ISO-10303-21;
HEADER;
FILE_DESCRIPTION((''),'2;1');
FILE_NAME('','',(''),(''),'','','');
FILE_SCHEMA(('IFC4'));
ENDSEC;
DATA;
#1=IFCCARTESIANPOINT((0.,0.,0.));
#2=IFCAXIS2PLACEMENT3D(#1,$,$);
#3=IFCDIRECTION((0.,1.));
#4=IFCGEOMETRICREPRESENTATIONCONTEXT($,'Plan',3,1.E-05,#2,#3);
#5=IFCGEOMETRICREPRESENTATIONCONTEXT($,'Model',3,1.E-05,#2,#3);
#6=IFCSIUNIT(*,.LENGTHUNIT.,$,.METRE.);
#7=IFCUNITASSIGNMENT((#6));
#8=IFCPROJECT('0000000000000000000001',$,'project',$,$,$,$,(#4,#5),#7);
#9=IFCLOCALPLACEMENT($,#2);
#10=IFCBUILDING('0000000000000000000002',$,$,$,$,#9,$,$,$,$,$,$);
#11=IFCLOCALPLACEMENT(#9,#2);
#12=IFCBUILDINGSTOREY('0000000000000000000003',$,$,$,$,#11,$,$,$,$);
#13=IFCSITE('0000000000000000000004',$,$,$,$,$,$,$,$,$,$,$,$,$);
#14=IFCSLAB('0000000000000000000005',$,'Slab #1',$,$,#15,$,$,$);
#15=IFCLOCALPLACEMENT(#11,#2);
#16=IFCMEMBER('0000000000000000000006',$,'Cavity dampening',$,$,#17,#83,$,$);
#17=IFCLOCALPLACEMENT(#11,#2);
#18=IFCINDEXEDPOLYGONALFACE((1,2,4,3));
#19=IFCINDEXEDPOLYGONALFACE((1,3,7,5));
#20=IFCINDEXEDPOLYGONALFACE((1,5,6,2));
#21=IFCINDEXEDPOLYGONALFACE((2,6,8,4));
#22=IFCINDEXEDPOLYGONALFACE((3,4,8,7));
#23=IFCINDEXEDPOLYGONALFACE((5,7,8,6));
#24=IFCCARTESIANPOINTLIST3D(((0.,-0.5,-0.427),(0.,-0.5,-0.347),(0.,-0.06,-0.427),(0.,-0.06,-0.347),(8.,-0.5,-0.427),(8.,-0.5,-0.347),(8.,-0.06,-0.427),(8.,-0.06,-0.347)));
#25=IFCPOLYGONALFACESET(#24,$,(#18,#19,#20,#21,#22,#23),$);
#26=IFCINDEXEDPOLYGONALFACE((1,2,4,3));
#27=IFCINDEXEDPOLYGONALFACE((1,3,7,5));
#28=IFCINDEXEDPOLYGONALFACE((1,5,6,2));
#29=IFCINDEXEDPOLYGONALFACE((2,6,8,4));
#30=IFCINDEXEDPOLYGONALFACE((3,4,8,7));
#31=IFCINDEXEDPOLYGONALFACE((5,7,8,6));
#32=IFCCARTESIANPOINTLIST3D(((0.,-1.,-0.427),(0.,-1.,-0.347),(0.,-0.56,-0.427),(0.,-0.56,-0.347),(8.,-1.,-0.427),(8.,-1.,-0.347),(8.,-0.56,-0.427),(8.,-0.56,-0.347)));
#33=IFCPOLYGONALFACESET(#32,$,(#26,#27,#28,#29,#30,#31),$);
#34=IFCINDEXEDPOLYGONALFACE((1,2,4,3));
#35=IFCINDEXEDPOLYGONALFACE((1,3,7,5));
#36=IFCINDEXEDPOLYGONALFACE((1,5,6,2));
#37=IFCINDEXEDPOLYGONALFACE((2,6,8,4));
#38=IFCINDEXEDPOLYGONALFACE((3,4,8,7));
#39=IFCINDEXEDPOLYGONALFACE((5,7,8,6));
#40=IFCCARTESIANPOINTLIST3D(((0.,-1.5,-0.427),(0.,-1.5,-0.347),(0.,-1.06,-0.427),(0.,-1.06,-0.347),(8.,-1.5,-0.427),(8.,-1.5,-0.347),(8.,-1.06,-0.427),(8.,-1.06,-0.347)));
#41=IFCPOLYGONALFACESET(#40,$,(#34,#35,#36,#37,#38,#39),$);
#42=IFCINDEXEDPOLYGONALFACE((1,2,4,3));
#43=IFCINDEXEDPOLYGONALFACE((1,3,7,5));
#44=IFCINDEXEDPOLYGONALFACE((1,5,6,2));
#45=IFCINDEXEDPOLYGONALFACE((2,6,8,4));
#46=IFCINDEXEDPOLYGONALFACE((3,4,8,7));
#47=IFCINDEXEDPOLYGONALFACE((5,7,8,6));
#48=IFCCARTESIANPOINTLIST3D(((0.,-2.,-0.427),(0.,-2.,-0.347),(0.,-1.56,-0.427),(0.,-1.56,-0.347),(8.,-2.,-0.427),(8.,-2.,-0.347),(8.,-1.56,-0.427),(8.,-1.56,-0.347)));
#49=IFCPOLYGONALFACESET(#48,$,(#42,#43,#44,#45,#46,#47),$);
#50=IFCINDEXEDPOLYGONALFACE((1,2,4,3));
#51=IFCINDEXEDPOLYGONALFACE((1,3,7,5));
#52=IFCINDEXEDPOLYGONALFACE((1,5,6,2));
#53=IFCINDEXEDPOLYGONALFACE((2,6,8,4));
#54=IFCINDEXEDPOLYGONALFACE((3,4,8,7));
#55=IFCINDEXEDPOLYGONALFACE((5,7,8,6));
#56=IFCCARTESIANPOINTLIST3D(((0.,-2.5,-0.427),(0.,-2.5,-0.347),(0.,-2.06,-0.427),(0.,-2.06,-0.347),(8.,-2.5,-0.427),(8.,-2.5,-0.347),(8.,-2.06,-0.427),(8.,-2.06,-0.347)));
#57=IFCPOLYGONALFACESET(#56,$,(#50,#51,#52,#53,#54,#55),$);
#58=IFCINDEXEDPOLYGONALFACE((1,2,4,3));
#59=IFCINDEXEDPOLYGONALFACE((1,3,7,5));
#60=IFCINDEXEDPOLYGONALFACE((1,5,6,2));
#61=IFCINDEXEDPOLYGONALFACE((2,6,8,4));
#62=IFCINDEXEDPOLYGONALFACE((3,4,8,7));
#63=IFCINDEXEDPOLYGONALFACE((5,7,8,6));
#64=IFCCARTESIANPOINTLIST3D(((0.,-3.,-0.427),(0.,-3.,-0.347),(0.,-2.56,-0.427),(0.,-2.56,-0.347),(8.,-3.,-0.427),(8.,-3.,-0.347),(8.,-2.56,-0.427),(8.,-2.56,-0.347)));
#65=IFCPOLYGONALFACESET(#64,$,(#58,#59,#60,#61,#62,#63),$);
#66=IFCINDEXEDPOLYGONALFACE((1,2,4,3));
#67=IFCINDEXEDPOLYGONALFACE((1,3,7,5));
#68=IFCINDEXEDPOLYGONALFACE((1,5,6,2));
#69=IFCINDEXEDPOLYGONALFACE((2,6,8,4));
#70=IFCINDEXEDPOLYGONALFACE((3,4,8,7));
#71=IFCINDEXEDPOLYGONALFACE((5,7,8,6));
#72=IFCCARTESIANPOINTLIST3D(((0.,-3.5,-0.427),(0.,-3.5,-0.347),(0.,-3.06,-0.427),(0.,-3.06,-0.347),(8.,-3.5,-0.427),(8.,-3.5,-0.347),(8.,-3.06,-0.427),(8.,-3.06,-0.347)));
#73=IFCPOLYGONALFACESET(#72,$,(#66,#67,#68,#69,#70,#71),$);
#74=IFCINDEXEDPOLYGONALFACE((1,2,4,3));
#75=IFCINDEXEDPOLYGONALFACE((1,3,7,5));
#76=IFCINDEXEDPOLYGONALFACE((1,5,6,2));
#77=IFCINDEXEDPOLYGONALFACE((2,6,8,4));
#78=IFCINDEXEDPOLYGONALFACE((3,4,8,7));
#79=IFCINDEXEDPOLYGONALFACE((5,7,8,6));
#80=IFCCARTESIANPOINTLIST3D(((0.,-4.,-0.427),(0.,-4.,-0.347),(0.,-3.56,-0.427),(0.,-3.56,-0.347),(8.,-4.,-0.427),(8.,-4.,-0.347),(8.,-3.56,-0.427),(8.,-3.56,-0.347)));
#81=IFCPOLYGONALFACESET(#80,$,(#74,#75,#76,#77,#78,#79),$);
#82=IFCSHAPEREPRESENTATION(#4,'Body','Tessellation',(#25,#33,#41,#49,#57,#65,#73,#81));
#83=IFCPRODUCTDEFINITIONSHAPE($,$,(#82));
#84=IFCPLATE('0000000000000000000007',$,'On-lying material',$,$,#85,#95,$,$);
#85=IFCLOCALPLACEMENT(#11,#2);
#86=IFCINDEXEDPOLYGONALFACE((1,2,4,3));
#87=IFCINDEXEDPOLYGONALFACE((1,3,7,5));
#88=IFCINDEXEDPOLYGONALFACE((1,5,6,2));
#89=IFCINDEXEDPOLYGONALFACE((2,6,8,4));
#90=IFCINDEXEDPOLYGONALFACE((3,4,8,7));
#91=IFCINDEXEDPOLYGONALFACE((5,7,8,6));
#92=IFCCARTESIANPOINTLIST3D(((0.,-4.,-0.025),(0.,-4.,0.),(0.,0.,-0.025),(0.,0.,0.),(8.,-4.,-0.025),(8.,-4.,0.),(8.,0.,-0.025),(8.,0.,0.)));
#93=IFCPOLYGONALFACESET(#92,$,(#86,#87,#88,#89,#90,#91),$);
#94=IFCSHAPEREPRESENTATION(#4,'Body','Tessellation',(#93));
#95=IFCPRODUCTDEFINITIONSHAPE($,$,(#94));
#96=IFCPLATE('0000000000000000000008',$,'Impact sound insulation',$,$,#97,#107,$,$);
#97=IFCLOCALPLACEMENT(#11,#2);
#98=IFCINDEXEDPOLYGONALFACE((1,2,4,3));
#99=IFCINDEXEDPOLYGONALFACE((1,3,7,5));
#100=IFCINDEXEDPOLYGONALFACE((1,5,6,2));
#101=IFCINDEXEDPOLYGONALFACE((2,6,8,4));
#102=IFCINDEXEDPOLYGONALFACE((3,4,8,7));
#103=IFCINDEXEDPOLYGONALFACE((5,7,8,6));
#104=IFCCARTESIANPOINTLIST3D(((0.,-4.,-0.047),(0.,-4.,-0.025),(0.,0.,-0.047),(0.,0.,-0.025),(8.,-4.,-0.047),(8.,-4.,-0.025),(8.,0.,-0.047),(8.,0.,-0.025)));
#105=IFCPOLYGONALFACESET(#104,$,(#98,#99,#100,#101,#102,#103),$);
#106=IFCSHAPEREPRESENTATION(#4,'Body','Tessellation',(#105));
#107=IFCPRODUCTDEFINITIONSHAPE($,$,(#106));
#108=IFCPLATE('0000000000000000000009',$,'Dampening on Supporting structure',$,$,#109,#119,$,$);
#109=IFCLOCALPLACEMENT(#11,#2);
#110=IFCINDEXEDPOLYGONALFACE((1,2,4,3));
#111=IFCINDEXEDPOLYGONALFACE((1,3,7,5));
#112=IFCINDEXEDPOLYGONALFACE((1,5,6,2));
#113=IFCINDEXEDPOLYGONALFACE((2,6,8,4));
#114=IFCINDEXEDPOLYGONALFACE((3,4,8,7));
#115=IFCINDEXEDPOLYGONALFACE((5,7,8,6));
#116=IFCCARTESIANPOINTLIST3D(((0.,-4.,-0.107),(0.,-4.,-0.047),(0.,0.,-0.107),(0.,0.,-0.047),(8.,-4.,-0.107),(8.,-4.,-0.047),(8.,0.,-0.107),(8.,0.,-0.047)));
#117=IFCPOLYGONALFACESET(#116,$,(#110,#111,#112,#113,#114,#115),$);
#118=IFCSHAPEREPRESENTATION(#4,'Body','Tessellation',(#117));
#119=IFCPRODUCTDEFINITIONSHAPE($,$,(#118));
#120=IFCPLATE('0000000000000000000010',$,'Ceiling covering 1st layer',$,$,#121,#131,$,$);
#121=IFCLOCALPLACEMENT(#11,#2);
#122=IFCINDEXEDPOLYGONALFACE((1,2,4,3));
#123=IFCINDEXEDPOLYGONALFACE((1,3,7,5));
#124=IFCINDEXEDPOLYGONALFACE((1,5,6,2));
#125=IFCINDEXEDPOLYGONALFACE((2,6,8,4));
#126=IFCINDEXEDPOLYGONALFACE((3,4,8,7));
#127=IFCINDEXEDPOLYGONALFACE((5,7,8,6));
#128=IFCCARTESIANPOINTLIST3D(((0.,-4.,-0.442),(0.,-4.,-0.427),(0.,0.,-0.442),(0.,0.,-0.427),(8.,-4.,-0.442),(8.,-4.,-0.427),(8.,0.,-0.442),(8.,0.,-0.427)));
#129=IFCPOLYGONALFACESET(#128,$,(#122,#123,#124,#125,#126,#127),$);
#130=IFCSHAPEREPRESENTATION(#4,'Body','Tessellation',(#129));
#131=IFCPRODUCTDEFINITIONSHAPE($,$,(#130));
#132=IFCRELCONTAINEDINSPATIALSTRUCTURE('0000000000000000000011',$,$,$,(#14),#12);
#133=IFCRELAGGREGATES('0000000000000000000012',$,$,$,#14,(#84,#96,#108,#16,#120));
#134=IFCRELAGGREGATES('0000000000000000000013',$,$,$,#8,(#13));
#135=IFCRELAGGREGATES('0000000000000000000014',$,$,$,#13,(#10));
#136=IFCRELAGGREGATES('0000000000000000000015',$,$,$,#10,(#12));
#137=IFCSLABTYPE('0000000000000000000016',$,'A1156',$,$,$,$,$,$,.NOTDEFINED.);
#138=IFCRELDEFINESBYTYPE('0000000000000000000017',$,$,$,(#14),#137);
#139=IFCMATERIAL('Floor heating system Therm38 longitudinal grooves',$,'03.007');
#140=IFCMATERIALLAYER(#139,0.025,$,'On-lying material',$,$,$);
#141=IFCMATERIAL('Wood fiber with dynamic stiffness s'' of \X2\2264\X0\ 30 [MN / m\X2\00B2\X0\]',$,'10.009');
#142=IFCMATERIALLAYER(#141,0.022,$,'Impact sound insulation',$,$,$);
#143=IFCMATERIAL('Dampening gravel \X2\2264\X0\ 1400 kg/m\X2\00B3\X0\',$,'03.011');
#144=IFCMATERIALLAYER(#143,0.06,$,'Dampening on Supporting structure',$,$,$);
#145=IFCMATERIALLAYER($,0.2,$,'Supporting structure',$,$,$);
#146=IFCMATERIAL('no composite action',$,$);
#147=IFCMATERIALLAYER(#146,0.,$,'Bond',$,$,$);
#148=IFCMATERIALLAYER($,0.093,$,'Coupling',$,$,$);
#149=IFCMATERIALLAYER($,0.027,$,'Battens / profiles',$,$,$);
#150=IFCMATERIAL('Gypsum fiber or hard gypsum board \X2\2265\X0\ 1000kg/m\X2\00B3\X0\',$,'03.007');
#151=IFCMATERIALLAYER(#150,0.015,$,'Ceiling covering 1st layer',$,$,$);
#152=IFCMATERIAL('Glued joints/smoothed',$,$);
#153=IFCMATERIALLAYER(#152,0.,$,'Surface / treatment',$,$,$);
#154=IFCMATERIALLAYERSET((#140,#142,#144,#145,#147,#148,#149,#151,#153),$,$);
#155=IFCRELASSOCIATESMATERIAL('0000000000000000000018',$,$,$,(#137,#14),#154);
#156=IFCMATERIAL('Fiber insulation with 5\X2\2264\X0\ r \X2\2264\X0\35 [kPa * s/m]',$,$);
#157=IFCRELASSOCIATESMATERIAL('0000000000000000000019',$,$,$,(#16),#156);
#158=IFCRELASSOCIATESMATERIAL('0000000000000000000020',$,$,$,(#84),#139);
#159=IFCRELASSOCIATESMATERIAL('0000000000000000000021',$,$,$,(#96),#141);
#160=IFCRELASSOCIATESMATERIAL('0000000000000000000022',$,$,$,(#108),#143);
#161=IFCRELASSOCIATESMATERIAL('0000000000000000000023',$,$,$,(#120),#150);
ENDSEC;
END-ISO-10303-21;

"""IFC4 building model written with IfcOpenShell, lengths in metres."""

from ifc_helpers import new_model, si_unit, direction, frame, frame_2d, origin, origin_with_axes, place, context, project, spatial, rectangle, extrude, material, layer, layer_set, type_object, element, aggregate, save


model = new_model("IFC4")

# Units and contexts
plan_context = context("Plan", 3, precision=1e-05, world=origin(), true_north=direction((0.0, 1.0)))
model_context = context("Model", 3, precision=1e-05, world=origin(), true_north=direction((0.0, 1.0)))
ifc_project = project(units=[si_unit("LENGTHUNIT", "METRE")], contexts=[plan_context, model_context])

# Site, building, storey
site = spatial("IfcSite", under=ifc_project)
building_placement = place(None, origin())
building = spatial("IfcBuilding", under=site, at=building_placement)
storey_placement = place(building_placement, origin())
storey = spatial("IfcBuildingStorey", under=building, at=storey_placement)

# Slab, member, plates
ifc_material_1 = material(Name="Floor heating system Therm38 longitudinal grooves", Category="03.007")
ifc_layer_1 = layer(ifc_material_1, 0.025, Name="On-lying material")
ifc_material_2 = material(Name="Wood fiber with dynamic stiffness s' of ≤ 30 [MN / m²]", Category="10.009")
ifc_layer_2 = layer(ifc_material_2, 0.022, Name="Impact sound insulation")
ifc_material_3 = material(Name="Dampening gravel ≤ 1400 kg/m³", Category="03.011")
ifc_layer_3 = layer(ifc_material_3, 0.06, Name="Dampening on Supporting structure")
ifc_layer_4 = layer(None, 0.2, Name="Supporting structure")
ifc_material_4 = material(Name="no composite action")
ifc_layer_5 = layer(ifc_material_4, 0.0, Name="Bond")
ifc_layer_6 = layer(None, 0.093, Name="Coupling")
ifc_layer_7 = layer(None, 0.027, Name="Battens / profiles")
ifc_material_5 = material(Name="Gypsum fiber or hard gypsum board ≥ 1000kg/m³", Category="03.007")
ifc_layer_8 = layer(ifc_material_5, 0.015, Name="Ceiling covering 1st layer")
ifc_material_6 = material(Name="Glued joints/smoothed")
ifc_layer_9 = layer(ifc_material_6, 0.0, Name="Surface / treatment")
ifc_layer_set = layer_set([ifc_layer_1, ifc_layer_2, ifc_layer_3, ifc_layer_4, ifc_layer_5, ifc_layer_6, ifc_layer_7, ifc_layer_8, ifc_layer_9])
slab_type = type_object("IfcSlabType", Name="A1156", PredefinedType="NOTDEFINED", material=ifc_layer_set)
slab_placement = place(None, frame((0.0, 0.0, 0.0), z_axis=(0.0, 0.0, -1.0), x_axis=(1.0, 0.0, 0.0)))
slab = element("IfcSlab", 1, at=slab_placement, inside=storey, type_object=slab_type, material=ifc_layer_set, Name="Slab #1")
ifc_material_7 = material(Name="Fiber insulation with 5≤ r ≤35 [kPa * s/m]")
member_1_placement = place(slab_placement, origin())
member_1 = element("IfcMember", 2, at=member_1_placement, material=ifc_material_7, Name="Cavity dampening", context=plan_context, shape_type="SweptSolid", body=[
    extrude(rectangle(XDim=0.44, YDim=0.08, at=frame_2d((0.22, 0.04), x_axis=(1.0, 0.0))), frame((0.0, 0.06, 0.347), z_axis=(1.0, 0.0, 0.0), x_axis=(0.0, 1.0, 0.0)), (0.0, 0.0, 1.0), 8.0),
    extrude(rectangle(XDim=0.44, YDim=0.08, at=frame_2d((0.22, 0.04), x_axis=(1.0, 0.0))), frame((0.0, 0.56, 0.347), z_axis=(1.0, 0.0, 0.0), x_axis=(0.0, 1.0, 0.0)), (0.0, 0.0, 1.0), 8.0),
    extrude(rectangle(XDim=0.44, YDim=0.08, at=frame_2d((0.22, 0.04), x_axis=(1.0, 0.0))), frame((0.0, 1.06, 0.347), z_axis=(1.0, 0.0, 0.0), x_axis=(0.0, 1.0, 0.0)), (0.0, 0.0, 1.0), 8.0),
    extrude(rectangle(XDim=0.44, YDim=0.08, at=frame_2d((0.22, 0.04), x_axis=(1.0, 0.0))), frame((0.0, 1.56, 0.347), z_axis=(1.0, 0.0, 0.0), x_axis=(0.0, 1.0, 0.0)), (0.0, 0.0, 1.0), 8.0),
    extrude(rectangle(XDim=0.44, YDim=0.08, at=frame_2d((0.22, 0.04), x_axis=(1.0, 0.0))), frame((0.0, 2.06, 0.347), z_axis=(1.0, 0.0, 0.0), x_axis=(0.0, 1.0, 0.0)), (0.0, 0.0, 1.0), 8.0),
    extrude(rectangle(XDim=0.44, YDim=0.08, at=frame_2d((0.22, 0.04), x_axis=(1.0, 0.0))), frame((0.0, 2.56, 0.347), z_axis=(1.0, 0.0, 0.0), x_axis=(0.0, 1.0, 0.0)), (0.0, 0.0, 1.0), 8.0),
    extrude(rectangle(XDim=0.44, YDim=0.08, at=frame_2d((0.22, 0.04), x_axis=(1.0, 0.0))), frame((0.0, 3.06, 0.347), z_axis=(1.0, 0.0, 0.0), x_axis=(0.0, 1.0, 0.0)), (0.0, 0.0, 1.0), 8.0),
    extrude(rectangle(XDim=0.44, YDim=0.08, at=frame_2d((0.22, 0.04), x_axis=(1.0, 0.0))), frame((0.0, 3.56, 0.347), z_axis=(1.0, 0.0, 0.0), x_axis=(0.0, 1.0, 0.0)), (0.0, 0.0, 1.0), 8.0),
])
plate_1_placement = place(slab_placement, origin())
plate_1 = element("IfcPlate", 3, at=plate_1_placement, material=ifc_material_1, Name="On-lying material", context=plan_context, shape_type="SweptSolid", body=[
    extrude(rectangle(XDim=8.0, YDim=4.0, at=frame_2d((4.0, 2.0), x_axis=(1.0, 0.0))), origin_with_axes(), (0.0, 0.0, 1.0), 0.025),
])
plate_2_placement = place(slab_placement, origin())
plate_2 = element("IfcPlate", 4, at=plate_2_placement, material=ifc_material_2, Name="Impact sound insulation", context=plan_context, shape_type="SweptSolid", body=[
    extrude(rectangle(XDim=8.0, YDim=4.0, at=frame_2d((4.0, 2.0), x_axis=(1.0, 0.0))), frame((0.0, 0.0, 0.025), z_axis=(0.0, 0.0, 1.0), x_axis=(1.0, 0.0, 0.0)), (0.0, 0.0, 1.0), 0.022),
])
plate_3_placement = place(slab_placement, origin())
plate_3 = element("IfcPlate", 5, at=plate_3_placement, material=ifc_material_3, Name="Dampening on Supporting structure", context=plan_context, shape_type="SweptSolid", body=[
    extrude(rectangle(XDim=8.0, YDim=4.0, at=frame_2d((4.0, 2.0), x_axis=(1.0, 0.0))), frame((0.0, 0.0, 0.047), z_axis=(0.0, 0.0, 1.0), x_axis=(1.0, 0.0, 0.0)), (0.0, 0.0, 1.0), 0.06),
])
plate_4_placement = place(slab_placement, origin())
plate_4 = element("IfcPlate", 6, at=plate_4_placement, material=ifc_material_5, Name="Ceiling covering 1st layer", context=plan_context, shape_type="SweptSolid", body=[
    extrude(rectangle(XDim=8.0, YDim=4.0, at=frame_2d((4.0, 2.0), x_axis=(1.0, 0.0))), frame((0.0, 0.0, 0.427), z_axis=(0.0, 0.0, 1.0), x_axis=(1.0, 0.0, 0.0)), (0.0, 0.0, 1.0), 0.015),
])
aggregate(slab, [plate_1, plate_2, plate_3, member_1, plate_4])

save(model, "model.ifc")
